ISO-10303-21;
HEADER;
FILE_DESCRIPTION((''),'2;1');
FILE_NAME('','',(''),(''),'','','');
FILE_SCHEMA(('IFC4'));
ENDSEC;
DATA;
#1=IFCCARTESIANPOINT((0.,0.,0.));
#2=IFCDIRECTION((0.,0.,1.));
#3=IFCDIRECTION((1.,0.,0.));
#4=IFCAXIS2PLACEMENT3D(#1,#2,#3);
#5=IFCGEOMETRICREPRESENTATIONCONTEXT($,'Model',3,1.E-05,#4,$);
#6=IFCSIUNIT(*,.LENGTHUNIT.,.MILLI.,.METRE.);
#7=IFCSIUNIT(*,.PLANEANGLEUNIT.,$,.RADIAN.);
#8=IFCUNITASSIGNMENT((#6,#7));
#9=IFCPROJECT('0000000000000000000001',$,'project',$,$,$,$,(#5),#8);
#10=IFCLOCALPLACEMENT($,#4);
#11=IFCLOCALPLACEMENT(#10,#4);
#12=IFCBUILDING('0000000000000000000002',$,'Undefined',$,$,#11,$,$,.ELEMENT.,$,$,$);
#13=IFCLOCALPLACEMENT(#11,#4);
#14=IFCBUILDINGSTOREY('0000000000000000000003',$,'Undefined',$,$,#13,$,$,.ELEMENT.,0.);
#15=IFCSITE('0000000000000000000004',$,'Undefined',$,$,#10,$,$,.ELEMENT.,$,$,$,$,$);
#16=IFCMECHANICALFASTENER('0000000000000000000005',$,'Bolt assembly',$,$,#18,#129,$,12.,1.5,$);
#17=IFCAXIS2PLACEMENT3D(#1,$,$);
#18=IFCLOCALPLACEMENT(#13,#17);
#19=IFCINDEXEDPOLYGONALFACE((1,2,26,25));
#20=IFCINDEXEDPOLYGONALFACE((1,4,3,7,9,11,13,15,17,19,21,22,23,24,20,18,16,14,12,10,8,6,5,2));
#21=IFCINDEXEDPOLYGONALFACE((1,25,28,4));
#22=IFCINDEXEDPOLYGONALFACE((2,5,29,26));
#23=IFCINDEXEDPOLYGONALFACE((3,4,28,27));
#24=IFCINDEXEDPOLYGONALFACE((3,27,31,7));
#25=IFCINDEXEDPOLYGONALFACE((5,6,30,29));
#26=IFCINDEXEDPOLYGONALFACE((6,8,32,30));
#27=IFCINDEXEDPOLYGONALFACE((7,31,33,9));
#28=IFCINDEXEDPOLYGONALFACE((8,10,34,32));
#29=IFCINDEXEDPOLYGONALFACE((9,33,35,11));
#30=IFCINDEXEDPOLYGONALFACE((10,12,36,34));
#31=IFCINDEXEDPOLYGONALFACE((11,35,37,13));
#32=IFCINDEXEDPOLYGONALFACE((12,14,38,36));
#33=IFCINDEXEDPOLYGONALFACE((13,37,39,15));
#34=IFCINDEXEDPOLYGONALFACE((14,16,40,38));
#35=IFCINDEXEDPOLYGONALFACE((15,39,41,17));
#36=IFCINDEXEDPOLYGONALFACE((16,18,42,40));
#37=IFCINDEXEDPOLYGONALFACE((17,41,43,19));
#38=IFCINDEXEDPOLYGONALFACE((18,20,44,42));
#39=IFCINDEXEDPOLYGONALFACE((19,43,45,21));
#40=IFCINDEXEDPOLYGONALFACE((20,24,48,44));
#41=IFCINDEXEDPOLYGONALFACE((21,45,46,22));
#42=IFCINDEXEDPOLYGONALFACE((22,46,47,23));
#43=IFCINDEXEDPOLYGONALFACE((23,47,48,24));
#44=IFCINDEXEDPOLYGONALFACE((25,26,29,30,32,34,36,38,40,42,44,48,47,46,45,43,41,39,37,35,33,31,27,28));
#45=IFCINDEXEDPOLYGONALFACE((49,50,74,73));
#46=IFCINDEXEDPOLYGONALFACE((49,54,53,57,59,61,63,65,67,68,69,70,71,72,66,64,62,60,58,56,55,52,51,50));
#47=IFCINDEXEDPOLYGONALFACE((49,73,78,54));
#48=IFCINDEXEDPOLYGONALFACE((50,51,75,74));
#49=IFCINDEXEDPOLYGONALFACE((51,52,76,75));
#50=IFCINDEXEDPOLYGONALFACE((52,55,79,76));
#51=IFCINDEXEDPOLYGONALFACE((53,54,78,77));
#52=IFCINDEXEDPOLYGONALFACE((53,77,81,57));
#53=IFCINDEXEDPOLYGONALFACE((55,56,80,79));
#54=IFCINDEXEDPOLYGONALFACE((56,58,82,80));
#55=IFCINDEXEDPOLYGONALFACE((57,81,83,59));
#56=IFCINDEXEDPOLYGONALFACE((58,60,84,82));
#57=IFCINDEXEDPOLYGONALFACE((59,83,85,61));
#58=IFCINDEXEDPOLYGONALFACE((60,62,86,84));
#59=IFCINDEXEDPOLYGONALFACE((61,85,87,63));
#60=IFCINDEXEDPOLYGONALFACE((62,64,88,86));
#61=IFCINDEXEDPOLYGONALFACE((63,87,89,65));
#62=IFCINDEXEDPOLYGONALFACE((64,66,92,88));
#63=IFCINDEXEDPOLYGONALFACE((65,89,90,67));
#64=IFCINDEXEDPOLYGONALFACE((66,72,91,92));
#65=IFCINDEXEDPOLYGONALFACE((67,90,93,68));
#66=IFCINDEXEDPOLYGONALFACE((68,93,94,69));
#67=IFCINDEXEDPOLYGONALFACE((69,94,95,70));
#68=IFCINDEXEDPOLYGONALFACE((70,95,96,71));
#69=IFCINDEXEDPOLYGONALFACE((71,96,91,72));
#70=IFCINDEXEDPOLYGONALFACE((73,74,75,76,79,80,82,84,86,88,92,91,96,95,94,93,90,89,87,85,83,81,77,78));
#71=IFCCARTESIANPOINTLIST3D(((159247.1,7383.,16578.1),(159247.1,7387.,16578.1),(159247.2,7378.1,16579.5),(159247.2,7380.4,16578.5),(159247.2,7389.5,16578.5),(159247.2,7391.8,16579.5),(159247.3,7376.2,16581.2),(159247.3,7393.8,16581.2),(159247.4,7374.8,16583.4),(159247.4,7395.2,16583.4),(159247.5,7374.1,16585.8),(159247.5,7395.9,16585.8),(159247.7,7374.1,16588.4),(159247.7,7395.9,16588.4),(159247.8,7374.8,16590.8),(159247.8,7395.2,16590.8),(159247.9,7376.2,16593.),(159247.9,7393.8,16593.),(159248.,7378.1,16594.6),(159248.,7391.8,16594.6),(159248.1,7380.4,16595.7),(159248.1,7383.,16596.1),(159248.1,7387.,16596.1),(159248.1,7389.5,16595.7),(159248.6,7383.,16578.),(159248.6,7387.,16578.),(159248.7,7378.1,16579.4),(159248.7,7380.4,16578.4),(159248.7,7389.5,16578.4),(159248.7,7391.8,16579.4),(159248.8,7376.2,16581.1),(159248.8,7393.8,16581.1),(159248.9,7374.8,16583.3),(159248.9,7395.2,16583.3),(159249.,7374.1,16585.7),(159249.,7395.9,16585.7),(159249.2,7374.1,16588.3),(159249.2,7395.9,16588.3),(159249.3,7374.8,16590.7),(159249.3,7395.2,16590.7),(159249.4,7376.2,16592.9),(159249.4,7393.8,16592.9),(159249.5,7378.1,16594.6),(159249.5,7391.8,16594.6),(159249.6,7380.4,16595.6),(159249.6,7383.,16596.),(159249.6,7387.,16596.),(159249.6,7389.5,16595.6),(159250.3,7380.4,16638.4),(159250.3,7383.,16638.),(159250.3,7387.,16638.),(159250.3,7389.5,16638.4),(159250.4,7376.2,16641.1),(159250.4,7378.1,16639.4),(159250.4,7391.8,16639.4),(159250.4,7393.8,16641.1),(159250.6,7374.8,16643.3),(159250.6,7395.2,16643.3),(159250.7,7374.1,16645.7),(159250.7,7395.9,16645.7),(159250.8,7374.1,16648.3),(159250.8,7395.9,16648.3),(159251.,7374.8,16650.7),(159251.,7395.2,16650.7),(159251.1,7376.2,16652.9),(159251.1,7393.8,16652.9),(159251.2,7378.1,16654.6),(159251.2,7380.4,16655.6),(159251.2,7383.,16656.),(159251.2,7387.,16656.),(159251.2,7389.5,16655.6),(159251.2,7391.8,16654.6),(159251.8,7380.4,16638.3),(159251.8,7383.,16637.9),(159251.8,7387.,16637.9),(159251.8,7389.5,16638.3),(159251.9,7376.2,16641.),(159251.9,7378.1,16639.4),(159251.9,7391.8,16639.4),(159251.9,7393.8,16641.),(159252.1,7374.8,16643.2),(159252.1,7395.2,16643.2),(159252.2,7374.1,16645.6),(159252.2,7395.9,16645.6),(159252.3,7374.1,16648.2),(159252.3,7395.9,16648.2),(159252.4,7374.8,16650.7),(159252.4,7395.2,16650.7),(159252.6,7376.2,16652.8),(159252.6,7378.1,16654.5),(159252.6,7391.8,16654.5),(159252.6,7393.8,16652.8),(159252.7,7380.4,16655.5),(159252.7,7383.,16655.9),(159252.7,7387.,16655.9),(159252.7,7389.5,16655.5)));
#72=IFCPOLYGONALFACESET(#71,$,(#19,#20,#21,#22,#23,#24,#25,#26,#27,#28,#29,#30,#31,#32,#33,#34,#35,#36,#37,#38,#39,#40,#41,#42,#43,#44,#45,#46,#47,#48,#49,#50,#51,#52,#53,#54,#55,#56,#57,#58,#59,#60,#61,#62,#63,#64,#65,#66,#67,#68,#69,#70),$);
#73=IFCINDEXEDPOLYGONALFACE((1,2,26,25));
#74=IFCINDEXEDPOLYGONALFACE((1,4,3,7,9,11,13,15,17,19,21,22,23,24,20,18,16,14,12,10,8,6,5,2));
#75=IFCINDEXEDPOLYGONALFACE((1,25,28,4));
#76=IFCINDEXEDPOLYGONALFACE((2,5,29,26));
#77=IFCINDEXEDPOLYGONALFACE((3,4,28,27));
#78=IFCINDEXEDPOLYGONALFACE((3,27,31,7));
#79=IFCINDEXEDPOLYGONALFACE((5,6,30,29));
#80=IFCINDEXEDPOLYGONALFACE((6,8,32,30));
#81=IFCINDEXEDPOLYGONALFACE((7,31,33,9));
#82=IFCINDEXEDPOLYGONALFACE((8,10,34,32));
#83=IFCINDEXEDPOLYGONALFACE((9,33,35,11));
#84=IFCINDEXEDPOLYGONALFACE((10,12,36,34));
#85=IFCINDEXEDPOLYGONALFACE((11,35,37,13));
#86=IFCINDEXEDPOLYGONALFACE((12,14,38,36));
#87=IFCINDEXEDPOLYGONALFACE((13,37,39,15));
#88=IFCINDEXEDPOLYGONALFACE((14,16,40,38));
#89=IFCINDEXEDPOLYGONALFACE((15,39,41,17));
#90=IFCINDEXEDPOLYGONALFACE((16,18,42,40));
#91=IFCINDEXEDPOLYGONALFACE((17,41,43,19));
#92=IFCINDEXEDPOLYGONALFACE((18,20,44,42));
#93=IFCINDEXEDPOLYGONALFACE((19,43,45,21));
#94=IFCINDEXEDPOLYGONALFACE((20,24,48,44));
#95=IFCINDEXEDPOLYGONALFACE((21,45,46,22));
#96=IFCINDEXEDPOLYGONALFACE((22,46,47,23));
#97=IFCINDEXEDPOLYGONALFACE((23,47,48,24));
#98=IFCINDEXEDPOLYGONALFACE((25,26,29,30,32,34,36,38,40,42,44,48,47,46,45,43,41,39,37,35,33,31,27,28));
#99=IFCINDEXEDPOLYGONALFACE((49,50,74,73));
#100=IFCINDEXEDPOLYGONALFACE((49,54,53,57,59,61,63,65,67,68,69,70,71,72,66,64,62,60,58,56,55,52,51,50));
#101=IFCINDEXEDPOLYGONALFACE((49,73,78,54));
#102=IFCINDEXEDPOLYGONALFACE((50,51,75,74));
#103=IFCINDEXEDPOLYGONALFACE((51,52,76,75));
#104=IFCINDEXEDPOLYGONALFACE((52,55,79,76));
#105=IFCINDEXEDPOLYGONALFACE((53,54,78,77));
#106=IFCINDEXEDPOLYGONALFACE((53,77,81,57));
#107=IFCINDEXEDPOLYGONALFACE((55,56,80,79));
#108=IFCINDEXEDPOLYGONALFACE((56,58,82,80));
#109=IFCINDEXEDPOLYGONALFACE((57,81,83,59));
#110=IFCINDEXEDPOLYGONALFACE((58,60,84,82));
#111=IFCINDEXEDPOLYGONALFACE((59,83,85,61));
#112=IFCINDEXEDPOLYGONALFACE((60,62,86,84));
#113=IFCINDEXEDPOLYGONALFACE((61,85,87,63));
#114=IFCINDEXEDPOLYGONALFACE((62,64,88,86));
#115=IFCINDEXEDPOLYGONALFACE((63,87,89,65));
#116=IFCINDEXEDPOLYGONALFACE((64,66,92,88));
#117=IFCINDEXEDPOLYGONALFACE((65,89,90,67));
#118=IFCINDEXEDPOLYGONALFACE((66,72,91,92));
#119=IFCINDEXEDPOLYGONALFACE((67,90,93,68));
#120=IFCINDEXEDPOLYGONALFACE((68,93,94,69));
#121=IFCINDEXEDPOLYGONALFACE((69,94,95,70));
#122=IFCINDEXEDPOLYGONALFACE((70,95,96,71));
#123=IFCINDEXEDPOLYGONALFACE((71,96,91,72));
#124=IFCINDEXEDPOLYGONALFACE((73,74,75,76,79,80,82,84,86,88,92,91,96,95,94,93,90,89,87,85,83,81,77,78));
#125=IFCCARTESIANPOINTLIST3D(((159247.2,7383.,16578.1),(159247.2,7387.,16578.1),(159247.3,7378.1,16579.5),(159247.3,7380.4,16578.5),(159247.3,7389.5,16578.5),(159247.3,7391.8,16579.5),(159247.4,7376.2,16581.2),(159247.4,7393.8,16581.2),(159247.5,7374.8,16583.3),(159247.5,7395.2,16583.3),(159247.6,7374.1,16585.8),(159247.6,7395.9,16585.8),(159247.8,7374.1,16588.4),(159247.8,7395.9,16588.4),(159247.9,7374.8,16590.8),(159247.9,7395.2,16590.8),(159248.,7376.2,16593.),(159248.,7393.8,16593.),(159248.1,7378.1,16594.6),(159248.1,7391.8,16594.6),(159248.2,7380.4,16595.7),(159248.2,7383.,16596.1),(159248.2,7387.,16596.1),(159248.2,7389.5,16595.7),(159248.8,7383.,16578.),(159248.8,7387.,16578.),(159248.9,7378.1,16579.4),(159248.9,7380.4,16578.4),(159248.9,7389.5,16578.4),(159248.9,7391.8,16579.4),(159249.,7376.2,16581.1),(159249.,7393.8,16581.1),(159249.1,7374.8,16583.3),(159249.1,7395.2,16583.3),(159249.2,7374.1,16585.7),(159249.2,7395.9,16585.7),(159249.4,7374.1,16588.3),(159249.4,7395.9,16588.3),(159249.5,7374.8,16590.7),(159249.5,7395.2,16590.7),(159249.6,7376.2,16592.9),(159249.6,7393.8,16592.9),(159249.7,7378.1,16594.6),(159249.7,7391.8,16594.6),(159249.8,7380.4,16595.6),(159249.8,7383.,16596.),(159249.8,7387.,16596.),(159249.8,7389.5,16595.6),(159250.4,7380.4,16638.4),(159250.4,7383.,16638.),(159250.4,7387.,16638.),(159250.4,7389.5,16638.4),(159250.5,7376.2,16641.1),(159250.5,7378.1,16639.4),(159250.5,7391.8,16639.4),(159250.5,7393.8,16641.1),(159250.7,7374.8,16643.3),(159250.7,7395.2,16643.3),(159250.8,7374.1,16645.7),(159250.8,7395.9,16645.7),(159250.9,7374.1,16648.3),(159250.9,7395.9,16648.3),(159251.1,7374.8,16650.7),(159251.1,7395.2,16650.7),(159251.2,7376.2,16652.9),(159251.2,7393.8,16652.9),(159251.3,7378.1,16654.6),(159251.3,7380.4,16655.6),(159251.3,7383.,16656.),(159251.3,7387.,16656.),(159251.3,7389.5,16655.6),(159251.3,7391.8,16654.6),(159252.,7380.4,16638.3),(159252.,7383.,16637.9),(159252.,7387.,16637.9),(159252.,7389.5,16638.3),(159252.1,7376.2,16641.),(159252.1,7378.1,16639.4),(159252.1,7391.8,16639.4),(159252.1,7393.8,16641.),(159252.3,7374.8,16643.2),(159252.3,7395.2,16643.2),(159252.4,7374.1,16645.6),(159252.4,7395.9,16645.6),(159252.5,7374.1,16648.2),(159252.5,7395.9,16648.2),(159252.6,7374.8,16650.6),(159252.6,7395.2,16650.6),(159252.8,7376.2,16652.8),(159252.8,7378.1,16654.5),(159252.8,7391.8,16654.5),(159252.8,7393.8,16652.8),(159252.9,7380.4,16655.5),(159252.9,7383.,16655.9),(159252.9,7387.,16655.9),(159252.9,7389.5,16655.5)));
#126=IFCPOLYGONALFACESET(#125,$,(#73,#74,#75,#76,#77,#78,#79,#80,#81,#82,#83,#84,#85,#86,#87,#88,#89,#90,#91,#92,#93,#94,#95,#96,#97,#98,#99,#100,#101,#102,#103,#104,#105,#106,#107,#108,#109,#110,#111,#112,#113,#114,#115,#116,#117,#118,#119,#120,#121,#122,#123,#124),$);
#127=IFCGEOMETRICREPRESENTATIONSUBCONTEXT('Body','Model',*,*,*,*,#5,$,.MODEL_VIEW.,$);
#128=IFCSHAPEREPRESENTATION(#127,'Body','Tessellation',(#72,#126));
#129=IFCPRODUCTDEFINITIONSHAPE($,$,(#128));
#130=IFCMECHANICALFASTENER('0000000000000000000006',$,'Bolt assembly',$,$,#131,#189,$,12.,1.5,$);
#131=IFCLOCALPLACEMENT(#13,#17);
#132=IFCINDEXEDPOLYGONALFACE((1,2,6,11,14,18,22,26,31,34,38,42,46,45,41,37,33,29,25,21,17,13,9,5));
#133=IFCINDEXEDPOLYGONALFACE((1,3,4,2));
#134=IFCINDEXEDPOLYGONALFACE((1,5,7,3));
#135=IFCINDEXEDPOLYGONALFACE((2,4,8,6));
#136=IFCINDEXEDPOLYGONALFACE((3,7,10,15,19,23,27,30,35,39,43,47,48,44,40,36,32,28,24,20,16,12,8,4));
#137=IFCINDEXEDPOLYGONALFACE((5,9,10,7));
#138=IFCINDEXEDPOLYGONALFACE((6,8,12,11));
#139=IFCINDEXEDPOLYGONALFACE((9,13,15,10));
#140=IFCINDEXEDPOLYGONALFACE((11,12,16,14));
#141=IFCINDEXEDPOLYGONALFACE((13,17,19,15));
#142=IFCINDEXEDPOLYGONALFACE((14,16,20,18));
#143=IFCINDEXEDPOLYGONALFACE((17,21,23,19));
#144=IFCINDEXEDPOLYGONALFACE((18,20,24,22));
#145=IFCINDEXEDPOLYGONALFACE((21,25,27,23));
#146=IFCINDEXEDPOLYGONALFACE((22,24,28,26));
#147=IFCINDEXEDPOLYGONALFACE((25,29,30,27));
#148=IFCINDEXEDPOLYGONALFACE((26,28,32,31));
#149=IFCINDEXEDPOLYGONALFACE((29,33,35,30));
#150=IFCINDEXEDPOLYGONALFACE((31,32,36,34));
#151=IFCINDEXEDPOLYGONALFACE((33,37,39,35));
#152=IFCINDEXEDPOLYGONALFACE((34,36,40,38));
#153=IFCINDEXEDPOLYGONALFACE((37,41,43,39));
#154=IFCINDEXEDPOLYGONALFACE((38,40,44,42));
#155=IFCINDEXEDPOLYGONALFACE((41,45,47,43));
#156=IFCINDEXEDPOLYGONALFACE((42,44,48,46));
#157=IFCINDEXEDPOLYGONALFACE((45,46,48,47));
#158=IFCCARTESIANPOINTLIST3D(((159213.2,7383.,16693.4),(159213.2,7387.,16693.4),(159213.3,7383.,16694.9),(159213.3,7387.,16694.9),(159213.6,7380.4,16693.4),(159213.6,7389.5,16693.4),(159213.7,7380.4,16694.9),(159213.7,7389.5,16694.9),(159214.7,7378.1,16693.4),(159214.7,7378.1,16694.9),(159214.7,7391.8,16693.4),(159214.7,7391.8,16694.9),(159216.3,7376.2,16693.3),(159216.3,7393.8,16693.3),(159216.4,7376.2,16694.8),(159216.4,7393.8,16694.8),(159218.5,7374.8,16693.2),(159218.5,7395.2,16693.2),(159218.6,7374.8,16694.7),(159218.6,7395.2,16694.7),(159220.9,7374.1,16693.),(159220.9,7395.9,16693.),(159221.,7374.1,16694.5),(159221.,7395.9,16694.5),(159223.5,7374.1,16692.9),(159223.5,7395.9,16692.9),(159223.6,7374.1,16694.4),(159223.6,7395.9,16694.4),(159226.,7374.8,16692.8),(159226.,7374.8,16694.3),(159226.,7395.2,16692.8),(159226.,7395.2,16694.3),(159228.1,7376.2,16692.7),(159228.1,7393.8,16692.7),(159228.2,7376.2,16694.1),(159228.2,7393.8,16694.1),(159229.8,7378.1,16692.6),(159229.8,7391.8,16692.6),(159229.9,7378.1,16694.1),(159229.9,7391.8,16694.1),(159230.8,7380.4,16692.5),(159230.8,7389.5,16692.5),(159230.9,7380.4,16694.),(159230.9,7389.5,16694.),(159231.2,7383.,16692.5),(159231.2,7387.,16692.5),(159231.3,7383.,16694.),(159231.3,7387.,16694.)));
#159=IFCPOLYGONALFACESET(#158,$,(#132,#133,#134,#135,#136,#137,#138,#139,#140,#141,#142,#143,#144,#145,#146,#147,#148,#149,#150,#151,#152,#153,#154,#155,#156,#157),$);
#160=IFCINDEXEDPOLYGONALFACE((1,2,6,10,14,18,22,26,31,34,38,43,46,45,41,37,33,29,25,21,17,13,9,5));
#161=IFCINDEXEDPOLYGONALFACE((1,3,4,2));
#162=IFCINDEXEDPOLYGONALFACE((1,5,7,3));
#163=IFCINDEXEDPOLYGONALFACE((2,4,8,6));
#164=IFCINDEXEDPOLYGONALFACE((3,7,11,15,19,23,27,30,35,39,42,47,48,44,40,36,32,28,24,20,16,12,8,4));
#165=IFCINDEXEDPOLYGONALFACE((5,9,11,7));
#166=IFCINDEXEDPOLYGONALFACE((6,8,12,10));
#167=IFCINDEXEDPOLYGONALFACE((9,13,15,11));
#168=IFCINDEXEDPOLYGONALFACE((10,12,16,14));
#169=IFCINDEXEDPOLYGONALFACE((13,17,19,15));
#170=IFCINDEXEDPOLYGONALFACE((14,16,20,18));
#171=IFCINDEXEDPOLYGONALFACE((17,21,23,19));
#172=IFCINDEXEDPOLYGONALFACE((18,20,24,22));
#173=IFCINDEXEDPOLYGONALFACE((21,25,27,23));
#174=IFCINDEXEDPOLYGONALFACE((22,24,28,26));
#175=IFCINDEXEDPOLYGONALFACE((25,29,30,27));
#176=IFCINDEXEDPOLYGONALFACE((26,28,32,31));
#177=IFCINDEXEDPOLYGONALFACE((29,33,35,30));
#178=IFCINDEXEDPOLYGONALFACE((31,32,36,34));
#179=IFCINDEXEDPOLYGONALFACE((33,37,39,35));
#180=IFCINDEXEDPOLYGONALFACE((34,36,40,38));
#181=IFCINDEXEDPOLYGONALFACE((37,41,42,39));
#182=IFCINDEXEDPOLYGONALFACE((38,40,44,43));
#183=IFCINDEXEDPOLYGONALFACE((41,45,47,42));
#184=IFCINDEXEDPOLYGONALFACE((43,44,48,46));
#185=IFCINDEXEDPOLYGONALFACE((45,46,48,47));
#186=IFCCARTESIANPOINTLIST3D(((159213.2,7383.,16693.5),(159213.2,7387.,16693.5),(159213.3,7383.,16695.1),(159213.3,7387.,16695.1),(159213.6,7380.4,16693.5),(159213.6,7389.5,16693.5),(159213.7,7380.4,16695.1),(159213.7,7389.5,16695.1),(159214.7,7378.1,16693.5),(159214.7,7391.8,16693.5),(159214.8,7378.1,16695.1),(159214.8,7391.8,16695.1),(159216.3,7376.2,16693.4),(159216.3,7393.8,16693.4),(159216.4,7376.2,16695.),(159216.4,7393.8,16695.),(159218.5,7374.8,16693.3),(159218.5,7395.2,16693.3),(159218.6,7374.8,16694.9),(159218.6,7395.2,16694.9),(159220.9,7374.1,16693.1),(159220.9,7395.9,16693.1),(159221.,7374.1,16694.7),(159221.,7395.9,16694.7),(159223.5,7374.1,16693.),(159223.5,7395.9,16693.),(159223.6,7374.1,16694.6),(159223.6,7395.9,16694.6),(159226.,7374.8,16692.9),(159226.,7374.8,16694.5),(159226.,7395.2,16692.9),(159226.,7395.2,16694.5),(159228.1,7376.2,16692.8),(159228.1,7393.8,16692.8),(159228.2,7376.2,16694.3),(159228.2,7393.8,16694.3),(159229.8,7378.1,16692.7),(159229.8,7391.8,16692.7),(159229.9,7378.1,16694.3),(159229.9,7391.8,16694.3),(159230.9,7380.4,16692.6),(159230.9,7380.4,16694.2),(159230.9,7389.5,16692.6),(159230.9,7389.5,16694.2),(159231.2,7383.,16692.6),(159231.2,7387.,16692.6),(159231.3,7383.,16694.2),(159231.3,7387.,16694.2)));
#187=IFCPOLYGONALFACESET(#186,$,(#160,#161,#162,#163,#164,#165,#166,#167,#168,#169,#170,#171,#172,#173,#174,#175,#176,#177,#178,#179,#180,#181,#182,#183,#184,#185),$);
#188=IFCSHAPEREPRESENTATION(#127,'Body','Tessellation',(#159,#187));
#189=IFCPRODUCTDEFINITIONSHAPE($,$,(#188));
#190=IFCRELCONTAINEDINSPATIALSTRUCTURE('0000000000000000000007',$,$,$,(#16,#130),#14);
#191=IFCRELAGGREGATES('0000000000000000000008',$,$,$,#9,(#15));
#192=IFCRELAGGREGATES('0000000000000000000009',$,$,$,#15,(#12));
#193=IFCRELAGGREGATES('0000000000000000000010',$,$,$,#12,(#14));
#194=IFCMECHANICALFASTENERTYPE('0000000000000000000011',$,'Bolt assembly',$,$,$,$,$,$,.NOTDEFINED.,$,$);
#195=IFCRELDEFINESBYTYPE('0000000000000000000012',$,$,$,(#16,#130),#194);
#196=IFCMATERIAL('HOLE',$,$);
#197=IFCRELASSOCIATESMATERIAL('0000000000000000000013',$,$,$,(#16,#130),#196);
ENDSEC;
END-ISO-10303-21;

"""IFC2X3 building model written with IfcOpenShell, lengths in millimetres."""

from ifc_helpers import new_model, entity, si_unit, frame, origin_with_axes, place, context, subcontext, project, spatial, source, transform, mapped, material, type_object, element, save


model = new_model("IFC2X3")

# Units and contexts
model_context = context("Model", 3, precision=1e-05, world=origin_with_axes())
body_context = subcontext(model_context, "Body", "Model", "MODEL_VIEW")
ifc_project = project(units=[si_unit("LENGTHUNIT", "METRE", prefix="MILLI"), si_unit("PLANEANGLEUNIT", "RADIAN")], contexts=[model_context])

# Site, building, storey
site_placement = place(None, origin_with_axes())
site = spatial("IfcSite", under=ifc_project, at=site_placement, Name="Undefined", CompositionType="ELEMENT")
building_placement = place(site_placement, origin_with_axes())
building = spatial("IfcBuilding", under=site, at=building_placement, Name="Undefined", CompositionType="ELEMENT")
storey_placement = place(building_placement, origin_with_axes())
storey = spatial("IfcBuildingStorey", under=building, at=storey_placement, Name="Undefined", CompositionType="ELEMENT", Elevation=0.0)

# Mechanical fasteners
ifc_material_1 = material(Name="HOLE")
mechanical_fastener_type = type_object("IfcMechanicalFastenerType", Name="Bolt assembly")
shared_circle_1 = entity("IfcCircle", entity("IfcAxis2Placement2D", entity("IfcCartesianPoint", [0.0, -2.0]), entity("IfcDirection", [1.0, 0.0])), 9.0)
shared_circle_2 = entity("IfcCircle", entity("IfcAxis2Placement2D", entity("IfcCartesianPoint", [0.0, 2.0]), entity("IfcDirection", [-1.0, 0.0])), 9.0)
shared_composite_curve = entity("IfcCompositeCurve", [entity("IfcCompositeCurveSegment", "CONTINUOUS", True, entity("IfcPolyline", [entity("IfcCartesianPoint", [9.0, 2.0]), entity("IfcCartesianPoint", [9.0, -2.0])])), entity("IfcCompositeCurveSegment", "CONTINUOUS", True, entity("IfcTrimmedCurve", shared_circle_1, [entity("IfcParameterValue", 0.0)], [entity("IfcParameterValue", 3.141593)], False, "PARAMETER")), entity("IfcCompositeCurveSegment", "CONTINUOUS", True, entity("IfcPolyline", [entity("IfcCartesianPoint", [-9.0, -2.0]), entity("IfcCartesianPoint", [-9.0, 2.0])])), entity("IfcCompositeCurveSegment", "DISCONTINUOUS", True, entity("IfcTrimmedCurve", shared_circle_2, [entity("IfcParameterValue", 0.0)], [entity("IfcParameterValue", 3.141593)], False, "PARAMETER"))], False)
shared_shape_1 = source(origin_with_axes(), body_context, "Body", "SweptSolid", [
    entity("IfcExtrudedAreaSolid", entity("IfcArbitraryClosedProfileDef", "AREA", None, shared_composite_curve), entity("IfcAxis2Placement3D", entity("IfcCartesianPoint", [0.0, 0.1, 0.0]), entity("IfcDirection", [0.0, 1.0, 0.0]), entity("IfcDirection", [1.0, 0.0, 0.0])), entity("IfcDirection", [0.0, 0.0, 1.0]), 1.5),
    entity("IfcExtrudedAreaSolid", entity("IfcArbitraryClosedProfileDef", "AREA", None, shared_composite_curve), entity("IfcAxis2Placement3D", entity("IfcCartesianPoint", [0.0, -0.1, 0.0]), entity("IfcDirection", [0.0, 1.0, 0.0]), entity("IfcDirection", [1.0, 0.0, 0.0])), entity("IfcDirection", [0.0, 0.0, 1.0]), 1.6),
])
mechanical_fastener_1_placement = place(storey_placement, frame((159252.4, 7385.0, 16646.9), z_axis=(0.0, 1.0, 0.0), x_axis=(-0.052392, 0.0, -0.998627)))
element("IfcMechanicalFastener", 1, at=mechanical_fastener_1_placement, inside=storey, type_object=mechanical_fastener_type, material=ifc_material_1, Name="Bolt assembly", NominalDiameter=12.0, NominalLength=1.5, context=body_context, shape_type="MappedRepresentation", body=[
    mapped(shared_shape_1, transform((0.0, 0.0, 0.0))),
    mapped(shared_shape_1, transform((60.0, 0.0, 0.0))),
])
shared_shape_2 = source(origin_with_axes(), body_context, "Body", "SweptSolid", [
    entity("IfcExtrudedAreaSolid", entity("IfcArbitraryClosedProfileDef", "AREA", None, shared_composite_curve), entity("IfcAxis2Placement3D", entity("IfcCartesianPoint", [0.0, -0.9, 0.0]), entity("IfcDirection", [0.0, 1.0, 0.0]), entity("IfcDirection", [1.0, 0.0, 0.0])), entity("IfcDirection", [0.0, 0.0, 1.0]), 1.5),
    entity("IfcExtrudedAreaSolid", entity("IfcArbitraryClosedProfileDef", "AREA", None, shared_composite_curve), entity("IfcAxis2Placement3D", entity("IfcCartesianPoint", [0.0, -1.1, 0.0]), entity("IfcDirection", [0.0, 1.0, 0.0]), entity("IfcDirection", [1.0, 0.0, 0.0])), entity("IfcDirection", [0.0, 0.0, 1.0]), 1.6),
])
mechanical_fastener_2_placement = place(storey_placement, frame((159222.3, 7385.0, 16693.6), z_axis=(0.0, 1.0, 0.0), x_axis=(0.998627, 0.0, -0.052392)))
element("IfcMechanicalFastener", 2, at=mechanical_fastener_2_placement, inside=storey, type_object=mechanical_fastener_type, material=ifc_material_1, Name="Bolt assembly", NominalDiameter=12.0, NominalLength=1.5, context=body_context, shape_type="MappedRepresentation", body=[
    mapped(shared_shape_2, transform((0.0, 0.0, 0.0))),
])

save(model, "model.ifc")
